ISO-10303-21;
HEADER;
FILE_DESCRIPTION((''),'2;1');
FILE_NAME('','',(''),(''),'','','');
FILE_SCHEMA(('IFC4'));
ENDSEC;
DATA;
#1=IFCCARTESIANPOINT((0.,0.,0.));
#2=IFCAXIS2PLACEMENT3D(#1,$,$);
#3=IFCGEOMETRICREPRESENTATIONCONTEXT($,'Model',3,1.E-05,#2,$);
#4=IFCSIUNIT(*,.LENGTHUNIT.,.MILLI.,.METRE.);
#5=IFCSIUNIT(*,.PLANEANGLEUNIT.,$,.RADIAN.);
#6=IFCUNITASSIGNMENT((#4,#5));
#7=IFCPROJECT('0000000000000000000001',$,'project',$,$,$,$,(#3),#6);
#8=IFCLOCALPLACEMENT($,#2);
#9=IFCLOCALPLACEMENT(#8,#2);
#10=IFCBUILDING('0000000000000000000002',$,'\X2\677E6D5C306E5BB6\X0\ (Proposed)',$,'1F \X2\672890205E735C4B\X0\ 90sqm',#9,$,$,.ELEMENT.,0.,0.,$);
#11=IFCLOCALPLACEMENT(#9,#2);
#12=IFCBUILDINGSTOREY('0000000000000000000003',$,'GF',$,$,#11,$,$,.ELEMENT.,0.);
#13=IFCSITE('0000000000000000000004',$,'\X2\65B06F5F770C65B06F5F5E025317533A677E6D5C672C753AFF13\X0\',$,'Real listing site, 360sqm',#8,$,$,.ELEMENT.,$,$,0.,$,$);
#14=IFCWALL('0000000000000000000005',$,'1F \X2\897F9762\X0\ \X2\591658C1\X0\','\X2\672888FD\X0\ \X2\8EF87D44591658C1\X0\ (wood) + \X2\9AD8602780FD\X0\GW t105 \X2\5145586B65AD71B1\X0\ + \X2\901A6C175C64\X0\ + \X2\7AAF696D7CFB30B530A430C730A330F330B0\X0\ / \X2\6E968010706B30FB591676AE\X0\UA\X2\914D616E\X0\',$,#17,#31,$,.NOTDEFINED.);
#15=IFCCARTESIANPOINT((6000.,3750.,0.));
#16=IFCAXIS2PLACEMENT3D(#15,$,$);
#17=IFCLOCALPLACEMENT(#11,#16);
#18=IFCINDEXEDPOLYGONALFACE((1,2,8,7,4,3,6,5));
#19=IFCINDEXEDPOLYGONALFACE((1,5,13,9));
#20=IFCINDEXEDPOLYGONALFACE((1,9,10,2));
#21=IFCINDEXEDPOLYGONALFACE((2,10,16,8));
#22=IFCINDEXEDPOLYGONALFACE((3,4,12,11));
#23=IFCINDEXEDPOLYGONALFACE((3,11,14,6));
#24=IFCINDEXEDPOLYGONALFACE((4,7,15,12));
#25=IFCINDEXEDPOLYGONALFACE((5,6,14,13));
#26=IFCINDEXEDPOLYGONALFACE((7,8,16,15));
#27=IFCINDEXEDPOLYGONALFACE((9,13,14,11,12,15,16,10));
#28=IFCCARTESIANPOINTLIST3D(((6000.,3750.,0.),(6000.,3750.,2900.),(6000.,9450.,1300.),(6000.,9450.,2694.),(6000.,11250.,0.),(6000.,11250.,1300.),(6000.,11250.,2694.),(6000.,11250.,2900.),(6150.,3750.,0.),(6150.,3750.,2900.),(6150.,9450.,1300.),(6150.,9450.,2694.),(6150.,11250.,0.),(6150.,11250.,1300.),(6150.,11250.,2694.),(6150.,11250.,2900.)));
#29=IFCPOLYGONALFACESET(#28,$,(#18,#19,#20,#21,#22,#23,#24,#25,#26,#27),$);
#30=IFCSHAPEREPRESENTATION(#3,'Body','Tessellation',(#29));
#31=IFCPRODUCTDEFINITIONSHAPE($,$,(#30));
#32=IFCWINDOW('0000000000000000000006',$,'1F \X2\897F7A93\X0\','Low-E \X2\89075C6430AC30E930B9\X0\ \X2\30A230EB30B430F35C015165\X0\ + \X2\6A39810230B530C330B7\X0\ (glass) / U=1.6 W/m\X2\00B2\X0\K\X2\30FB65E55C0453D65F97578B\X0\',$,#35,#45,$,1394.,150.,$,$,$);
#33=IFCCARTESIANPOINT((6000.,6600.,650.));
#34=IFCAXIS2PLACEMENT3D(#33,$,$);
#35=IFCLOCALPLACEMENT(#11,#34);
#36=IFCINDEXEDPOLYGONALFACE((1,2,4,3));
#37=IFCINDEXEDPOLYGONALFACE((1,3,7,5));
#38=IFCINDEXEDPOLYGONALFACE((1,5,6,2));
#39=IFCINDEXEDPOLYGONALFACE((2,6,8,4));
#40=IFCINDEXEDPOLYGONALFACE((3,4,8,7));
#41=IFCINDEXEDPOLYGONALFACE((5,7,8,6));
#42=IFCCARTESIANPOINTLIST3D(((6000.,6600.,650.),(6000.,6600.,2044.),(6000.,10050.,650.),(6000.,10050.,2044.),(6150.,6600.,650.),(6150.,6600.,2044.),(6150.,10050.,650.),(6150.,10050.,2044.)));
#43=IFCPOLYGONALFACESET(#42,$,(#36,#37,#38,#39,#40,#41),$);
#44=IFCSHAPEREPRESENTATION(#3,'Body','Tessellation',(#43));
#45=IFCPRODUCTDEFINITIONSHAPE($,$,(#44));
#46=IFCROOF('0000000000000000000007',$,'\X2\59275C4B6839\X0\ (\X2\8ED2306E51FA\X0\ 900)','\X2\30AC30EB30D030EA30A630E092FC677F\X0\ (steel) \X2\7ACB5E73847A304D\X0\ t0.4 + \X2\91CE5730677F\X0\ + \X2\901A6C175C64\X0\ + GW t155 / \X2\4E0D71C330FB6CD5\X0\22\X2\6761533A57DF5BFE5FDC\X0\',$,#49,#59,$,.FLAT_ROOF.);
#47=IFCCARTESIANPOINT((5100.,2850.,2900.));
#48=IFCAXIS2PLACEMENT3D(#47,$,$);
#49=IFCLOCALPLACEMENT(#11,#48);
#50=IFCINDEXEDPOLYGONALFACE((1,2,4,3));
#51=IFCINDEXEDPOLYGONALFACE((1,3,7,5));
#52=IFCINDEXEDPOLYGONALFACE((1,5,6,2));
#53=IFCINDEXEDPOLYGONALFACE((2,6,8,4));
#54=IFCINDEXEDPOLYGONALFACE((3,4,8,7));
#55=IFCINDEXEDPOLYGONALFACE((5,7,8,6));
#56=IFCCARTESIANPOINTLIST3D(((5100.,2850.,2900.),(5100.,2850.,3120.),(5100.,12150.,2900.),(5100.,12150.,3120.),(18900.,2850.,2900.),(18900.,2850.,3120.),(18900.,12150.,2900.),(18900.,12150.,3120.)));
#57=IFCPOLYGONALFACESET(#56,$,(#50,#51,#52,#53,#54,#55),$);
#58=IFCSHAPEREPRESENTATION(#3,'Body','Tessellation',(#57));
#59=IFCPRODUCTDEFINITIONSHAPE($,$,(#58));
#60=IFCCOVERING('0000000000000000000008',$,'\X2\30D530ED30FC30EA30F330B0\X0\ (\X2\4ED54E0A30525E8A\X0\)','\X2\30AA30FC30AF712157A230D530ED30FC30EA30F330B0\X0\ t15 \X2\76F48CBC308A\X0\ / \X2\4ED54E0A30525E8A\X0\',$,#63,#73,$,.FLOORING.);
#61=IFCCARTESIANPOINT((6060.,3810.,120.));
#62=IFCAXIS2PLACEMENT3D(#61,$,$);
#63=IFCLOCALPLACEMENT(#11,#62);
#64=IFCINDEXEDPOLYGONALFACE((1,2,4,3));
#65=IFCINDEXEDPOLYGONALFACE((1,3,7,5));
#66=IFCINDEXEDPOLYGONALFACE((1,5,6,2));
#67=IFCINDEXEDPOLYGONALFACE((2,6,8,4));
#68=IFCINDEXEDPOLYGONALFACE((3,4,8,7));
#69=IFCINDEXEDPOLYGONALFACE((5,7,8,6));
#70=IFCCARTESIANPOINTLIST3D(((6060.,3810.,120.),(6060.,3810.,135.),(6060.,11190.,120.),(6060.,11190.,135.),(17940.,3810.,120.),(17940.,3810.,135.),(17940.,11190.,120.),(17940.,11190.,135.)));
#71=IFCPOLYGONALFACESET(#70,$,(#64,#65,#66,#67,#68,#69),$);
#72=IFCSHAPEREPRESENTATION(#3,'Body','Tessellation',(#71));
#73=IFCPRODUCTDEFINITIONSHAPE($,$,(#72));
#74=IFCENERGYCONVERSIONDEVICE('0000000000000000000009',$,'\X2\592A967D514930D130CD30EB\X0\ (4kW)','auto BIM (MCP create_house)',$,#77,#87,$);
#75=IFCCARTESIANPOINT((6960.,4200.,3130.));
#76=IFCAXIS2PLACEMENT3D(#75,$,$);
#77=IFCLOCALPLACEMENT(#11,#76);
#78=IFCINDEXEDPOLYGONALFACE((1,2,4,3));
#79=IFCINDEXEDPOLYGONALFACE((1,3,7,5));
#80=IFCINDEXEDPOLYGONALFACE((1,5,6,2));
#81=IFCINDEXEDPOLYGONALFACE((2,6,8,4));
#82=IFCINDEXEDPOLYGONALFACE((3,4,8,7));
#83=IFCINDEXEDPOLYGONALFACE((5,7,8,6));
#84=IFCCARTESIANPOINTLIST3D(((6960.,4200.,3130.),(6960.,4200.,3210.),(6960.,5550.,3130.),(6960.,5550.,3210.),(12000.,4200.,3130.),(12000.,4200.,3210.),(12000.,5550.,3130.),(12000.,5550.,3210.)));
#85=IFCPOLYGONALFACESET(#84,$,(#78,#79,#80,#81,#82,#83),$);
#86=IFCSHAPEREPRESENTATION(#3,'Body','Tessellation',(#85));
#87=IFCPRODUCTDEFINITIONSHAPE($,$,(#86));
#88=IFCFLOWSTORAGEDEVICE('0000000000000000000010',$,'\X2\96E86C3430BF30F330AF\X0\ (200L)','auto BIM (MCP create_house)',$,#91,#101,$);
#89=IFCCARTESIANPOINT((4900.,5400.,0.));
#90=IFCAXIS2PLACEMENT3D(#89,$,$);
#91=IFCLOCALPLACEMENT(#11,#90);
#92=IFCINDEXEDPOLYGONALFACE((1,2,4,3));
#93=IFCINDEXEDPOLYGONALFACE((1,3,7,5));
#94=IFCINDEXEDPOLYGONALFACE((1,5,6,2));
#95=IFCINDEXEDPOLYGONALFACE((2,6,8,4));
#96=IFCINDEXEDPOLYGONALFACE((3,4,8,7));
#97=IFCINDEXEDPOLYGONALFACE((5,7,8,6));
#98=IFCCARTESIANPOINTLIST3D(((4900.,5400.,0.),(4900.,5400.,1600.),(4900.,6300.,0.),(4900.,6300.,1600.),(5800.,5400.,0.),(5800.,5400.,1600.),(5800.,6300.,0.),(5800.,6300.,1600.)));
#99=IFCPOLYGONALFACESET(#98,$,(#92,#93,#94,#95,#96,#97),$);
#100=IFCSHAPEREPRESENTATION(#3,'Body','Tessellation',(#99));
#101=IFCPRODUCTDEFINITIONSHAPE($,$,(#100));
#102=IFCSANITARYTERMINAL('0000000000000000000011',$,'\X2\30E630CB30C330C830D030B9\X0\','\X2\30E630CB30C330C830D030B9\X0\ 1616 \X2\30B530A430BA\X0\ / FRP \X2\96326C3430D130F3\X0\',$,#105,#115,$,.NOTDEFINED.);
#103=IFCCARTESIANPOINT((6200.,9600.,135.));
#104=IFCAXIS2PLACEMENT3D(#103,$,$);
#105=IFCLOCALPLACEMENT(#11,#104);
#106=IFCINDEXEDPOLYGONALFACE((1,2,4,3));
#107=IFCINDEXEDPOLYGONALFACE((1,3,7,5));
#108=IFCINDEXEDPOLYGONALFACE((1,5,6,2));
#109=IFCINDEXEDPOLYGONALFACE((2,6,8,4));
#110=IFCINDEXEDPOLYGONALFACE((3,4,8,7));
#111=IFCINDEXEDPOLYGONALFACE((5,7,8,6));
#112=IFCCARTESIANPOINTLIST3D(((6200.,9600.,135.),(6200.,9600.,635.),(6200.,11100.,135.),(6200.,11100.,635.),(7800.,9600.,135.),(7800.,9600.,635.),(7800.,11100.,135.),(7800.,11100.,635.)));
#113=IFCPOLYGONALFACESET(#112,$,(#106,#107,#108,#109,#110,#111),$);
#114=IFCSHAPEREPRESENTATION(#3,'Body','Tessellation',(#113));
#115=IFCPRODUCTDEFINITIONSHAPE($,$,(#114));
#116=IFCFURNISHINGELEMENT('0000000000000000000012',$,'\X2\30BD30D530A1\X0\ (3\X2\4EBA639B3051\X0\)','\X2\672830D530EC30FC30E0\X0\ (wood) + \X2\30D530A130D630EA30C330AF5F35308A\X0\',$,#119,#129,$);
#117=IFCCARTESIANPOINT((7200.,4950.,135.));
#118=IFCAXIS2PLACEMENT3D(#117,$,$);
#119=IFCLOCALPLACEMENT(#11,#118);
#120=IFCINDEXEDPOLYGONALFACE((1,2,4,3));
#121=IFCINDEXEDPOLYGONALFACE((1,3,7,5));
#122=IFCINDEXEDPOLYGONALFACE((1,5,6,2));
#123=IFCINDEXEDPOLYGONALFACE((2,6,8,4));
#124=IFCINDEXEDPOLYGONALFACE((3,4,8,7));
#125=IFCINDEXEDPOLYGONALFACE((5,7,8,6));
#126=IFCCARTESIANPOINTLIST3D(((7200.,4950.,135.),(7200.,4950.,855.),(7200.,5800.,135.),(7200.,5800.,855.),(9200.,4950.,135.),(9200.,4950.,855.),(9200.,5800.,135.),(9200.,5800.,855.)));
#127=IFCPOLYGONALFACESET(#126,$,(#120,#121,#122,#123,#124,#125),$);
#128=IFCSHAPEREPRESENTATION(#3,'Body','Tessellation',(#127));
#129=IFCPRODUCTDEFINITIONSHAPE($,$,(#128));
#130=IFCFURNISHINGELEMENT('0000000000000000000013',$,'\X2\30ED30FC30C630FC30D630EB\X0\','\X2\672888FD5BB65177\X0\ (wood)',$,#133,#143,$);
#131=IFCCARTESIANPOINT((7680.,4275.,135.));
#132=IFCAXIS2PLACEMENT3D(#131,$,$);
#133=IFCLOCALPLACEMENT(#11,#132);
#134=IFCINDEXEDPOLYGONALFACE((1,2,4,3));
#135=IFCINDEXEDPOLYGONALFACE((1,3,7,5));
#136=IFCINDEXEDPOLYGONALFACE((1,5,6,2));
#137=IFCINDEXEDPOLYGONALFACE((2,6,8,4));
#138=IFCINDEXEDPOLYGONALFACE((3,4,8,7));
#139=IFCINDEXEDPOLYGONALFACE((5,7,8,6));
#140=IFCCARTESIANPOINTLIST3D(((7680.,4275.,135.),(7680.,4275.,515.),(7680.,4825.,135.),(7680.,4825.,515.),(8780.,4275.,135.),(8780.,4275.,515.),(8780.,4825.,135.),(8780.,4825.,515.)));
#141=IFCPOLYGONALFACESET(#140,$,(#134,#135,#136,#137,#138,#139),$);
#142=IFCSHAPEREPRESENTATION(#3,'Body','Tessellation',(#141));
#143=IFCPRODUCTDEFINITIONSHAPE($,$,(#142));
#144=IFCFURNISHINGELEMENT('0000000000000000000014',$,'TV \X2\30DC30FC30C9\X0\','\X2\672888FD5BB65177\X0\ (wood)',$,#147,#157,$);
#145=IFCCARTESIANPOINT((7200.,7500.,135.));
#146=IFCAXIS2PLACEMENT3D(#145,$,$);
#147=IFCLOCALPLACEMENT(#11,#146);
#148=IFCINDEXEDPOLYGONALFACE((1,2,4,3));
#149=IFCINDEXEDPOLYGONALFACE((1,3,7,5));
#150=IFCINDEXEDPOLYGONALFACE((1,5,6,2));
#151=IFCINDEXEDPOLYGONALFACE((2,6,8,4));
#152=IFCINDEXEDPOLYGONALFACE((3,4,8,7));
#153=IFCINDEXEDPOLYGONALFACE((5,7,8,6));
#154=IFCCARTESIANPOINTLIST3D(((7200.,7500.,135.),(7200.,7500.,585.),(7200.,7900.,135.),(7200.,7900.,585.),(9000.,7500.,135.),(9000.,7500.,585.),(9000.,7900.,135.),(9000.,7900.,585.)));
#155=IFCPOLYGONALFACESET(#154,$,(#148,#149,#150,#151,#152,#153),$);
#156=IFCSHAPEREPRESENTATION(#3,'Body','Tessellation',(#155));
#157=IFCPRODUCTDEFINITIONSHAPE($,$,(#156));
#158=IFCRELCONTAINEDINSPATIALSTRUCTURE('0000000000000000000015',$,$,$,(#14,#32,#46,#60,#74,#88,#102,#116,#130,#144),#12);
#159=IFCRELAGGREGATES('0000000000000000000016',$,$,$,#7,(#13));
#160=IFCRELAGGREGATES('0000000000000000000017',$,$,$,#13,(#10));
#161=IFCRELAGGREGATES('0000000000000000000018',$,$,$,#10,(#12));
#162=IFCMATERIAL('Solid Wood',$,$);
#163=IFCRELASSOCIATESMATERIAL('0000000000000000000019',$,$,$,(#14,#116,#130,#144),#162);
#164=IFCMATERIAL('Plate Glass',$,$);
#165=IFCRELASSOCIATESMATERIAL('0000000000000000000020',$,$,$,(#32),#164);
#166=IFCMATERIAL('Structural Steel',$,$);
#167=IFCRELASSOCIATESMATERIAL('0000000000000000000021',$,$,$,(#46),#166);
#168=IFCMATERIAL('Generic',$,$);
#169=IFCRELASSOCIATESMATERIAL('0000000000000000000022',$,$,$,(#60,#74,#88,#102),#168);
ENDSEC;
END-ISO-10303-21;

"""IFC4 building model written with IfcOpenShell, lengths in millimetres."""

from ifc_helpers import new_model, si_unit, frame, frame_2d, origin, place, context, project, spatial, rectangle, extrude, material, element, fill, save


model = new_model("IFC4")

# Units and contexts
model_context = context("Model", 3, precision=1e-05, world=origin())
ifc_project = project(units=[si_unit("LENGTHUNIT", "METRE", prefix="MILLI"), si_unit("PLANEANGLEUNIT", "RADIAN")], contexts=[model_context])

# Site, building, storey
site_placement = place(None, origin())
site = spatial("IfcSite", under=ifc_project, at=site_placement, Name="新潟県新潟市北区松浜本町３", ObjectType="Real listing site, 360sqm", CompositionType="ELEMENT", RefElevation=0.0)
building_placement = place(site_placement, origin())
building = spatial("IfcBuilding", under=site, at=building_placement, Name="松浜の家 (Proposed)", ObjectType="1F 木造平屋 90sqm", CompositionType="ELEMENT", ElevationOfRefHeight=0.0, ElevationOfTerrain=0.0)
storey_placement = place(building_placement, origin())
storey = spatial("IfcBuildingStorey", under=building, at=storey_placement, Name="GF", CompositionType="ELEMENT", Elevation=0.0)

# Shared definitions
ifc_material_1 = material(Name="Solid Wood")

# Shared definitions
ifc_material_2 = material(Name="Plate Glass")

# Wall, opening, window
wall_1_placement = place(storey_placement, frame((6000.0, 3750.0, 0.0)))
wall_1 = element("IfcWall", 1, at=wall_1_placement, inside=storey, material=ifc_material_1, Name="1F 西面 外壁", Description="木製 軸組外壁 (wood) + 高性能GW t105 充填断熱 + 通気層 + 窯業系サイディング / 準耐火・外皮UA配慮", PredefinedType="NOTDEFINED", context=model_context, shape_type="SweptSolid", body=[
    extrude(rectangle(XDim=150.0, YDim=7500.0, at=frame_2d((75.0, 3750.0))), frame((6000.0, 3750.0, 0.0)), (0.0, 0.0, 1.0), 2900.0),
])
opening_1_placement = place(storey_placement, frame((6000.0, 6600.0, 650.0)))
opening_1 = element("IfcOpeningElement", 2, at=opening_1_placement, cuts=wall_1, PredefinedType="NOTDEFINED", context=model_context, shape_type="SweptSolid", body=[
    extrude(rectangle(XDim=150.0, YDim=3450.0, at=frame_2d((75.0, 1725.0))), frame((6000.0, 6600.0, 650.0)), (0.0, 0.0, 1.0), 1394.0),
])
window_1_placement = place(storey_placement, frame((6000.0, 6600.0, 650.0)))
window_1 = element("IfcWindow", 3, at=window_1_placement, inside=storey, material=ifc_material_2, Name="1F 西窓", Description="Low-E 複層ガラス アルゴン封入 + 樹脂サッシ (glass) / U=1.6 W/m²K・日射取得型", OverallHeight=1394.0, OverallWidth=150.0, context=model_context, shape_type="SweptSolid", body=[
    extrude(rectangle(XDim=150.0, YDim=3450.0, at=frame_2d((75.0, 1725.0))), frame((6000.0, 6600.0, 650.0)), (0.0, 0.0, 1.0), 1394.0),
])
fill(opening_1, window_1)

# Roof
ifc_material_3 = material(Name="Structural Steel")
roof_placement = place(storey_placement, frame((5100.0, 2850.0, 2900.0)))
element("IfcRoof", 4, at=roof_placement, inside=storey, material=ifc_material_3, Name="大屋根 (軒の出 900)", Description="ガルバリウム鋼板 (steel) 立平葺き t0.4 + 野地板 + 通気層 + GW t155 / 不燃・法22条区域対応", PredefinedType="FLAT_ROOF", context=model_context, shape_type="SweptSolid", body=[
    extrude(rectangle(XDim=13800.0, YDim=9300.0, at=frame_2d((6900.0, 4650.0))), frame((5100.0, 2850.0, 2900.0)), (0.0, 0.0, 1.0), 220.0),
])

# Covering
ifc_material_4 = material(Name="Generic")
covering_placement = place(storey_placement, frame((6060.0, 3810.0, 120.0)))
element("IfcCovering", 5, at=covering_placement, inside=storey, material=ifc_material_4, Name="フローリング (仕上げ床)", Description="オーク無垢フローリング t15 直貼り / 仕上げ床", PredefinedType="FLOORING", context=model_context, shape_type="SweptSolid", body=[
    extrude(rectangle(XDim=11880.0, YDim=7380.0, at=frame_2d((5940.0, 3690.0))), frame((6060.0, 3810.0, 120.0)), (0.0, 0.0, 1.0), 15.0),
])

# Energy conversion device
energy_conversion_device_placement = place(storey_placement, frame((6960.0, 4200.0, 3130.0)))
element("IfcEnergyConversionDevice", 6, at=energy_conversion_device_placement, inside=storey, material=ifc_material_4, Name="太陽光パネル (4kW)", Description="auto BIM (MCP create_house)", context=model_context, shape_type="SweptSolid", body=[
    extrude(rectangle(XDim=5040.0, YDim=1350.0, at=frame_2d((2520.0, 675.0))), frame((6960.0, 4200.0, 3130.0)), (0.0, 0.0, 1.0), 80.0),
])

# Flow storage device
flow_storage_device_placement = place(storey_placement, frame((4900.0, 5400.0, 0.0)))
element("IfcFlowStorageDevice", 7, at=flow_storage_device_placement, inside=storey, material=ifc_material_4, Name="雨水タンク (200L)", Description="auto BIM (MCP create_house)", context=model_context, shape_type="SweptSolid", body=[
    extrude(rectangle(XDim=900.0, YDim=900.0, at=frame_2d((450.0, 450.0))), frame((4900.0, 5400.0, 0.0)), (0.0, 0.0, 1.0), 1600.0),
])

# Sanitary terminal
sanitary_terminal_placement = place(storey_placement, frame((6200.0, 9600.0, 135.0)))
element("IfcSanitaryTerminal", 8, at=sanitary_terminal_placement, inside=storey, material=ifc_material_4, Name="ユニットバス", Description="ユニットバス 1616 サイズ / FRP 防水パン", PredefinedType="NOTDEFINED", context=model_context, shape_type="SweptSolid", body=[
    extrude(rectangle(XDim=1600.0, YDim=1500.0, at=frame_2d((800.0, 750.0))), frame((6200.0, 9600.0, 135.0)), (0.0, 0.0, 1.0), 500.0),
])

# Furnishing elements
furnishing_1_placement = place(storey_placement, frame((7200.0, 4950.0, 135.0)))
element("IfcFurnishingElement", 9, at=furnishing_1_placement, inside=storey, material=ifc_material_1, Name="ソファ (3人掛け)", Description="木フレーム (wood) + ファブリック張り", context=model_context, shape_type="SweptSolid", body=[
    extrude(rectangle(XDim=2000.0, YDim=850.0, at=frame_2d((1000.0, 425.0))), frame((7200.0, 4950.0, 135.0)), (0.0, 0.0, 1.0), 720.0),
])
furnishing_2_placement = place(storey_placement, frame((7680.0, 4275.0, 135.0)))
element("IfcFurnishingElement", 10, at=furnishing_2_placement, inside=storey, material=ifc_material_1, Name="ローテーブル", Description="木製家具 (wood)", context=model_context, shape_type="SweptSolid", body=[
    extrude(rectangle(XDim=1100.0, YDim=550.0, at=frame_2d((550.0, 275.0))), frame((7680.0, 4275.0, 135.0)), (0.0, 0.0, 1.0), 380.0),
])
furnishing_3_placement = place(storey_placement, frame((7200.0, 7500.0, 135.0)))
element("IfcFurnishingElement", 11, at=furnishing_3_placement, inside=storey, material=ifc_material_1, Name="TV ボード", Description="木製家具 (wood)", context=model_context, shape_type="SweptSolid", body=[
    extrude(rectangle(XDim=1800.0, YDim=400.0, at=frame_2d((900.0, 200.0))), frame((7200.0, 7500.0, 135.0)), (0.0, 0.0, 1.0), 450.0),
])

save(model, "model.ifc")
